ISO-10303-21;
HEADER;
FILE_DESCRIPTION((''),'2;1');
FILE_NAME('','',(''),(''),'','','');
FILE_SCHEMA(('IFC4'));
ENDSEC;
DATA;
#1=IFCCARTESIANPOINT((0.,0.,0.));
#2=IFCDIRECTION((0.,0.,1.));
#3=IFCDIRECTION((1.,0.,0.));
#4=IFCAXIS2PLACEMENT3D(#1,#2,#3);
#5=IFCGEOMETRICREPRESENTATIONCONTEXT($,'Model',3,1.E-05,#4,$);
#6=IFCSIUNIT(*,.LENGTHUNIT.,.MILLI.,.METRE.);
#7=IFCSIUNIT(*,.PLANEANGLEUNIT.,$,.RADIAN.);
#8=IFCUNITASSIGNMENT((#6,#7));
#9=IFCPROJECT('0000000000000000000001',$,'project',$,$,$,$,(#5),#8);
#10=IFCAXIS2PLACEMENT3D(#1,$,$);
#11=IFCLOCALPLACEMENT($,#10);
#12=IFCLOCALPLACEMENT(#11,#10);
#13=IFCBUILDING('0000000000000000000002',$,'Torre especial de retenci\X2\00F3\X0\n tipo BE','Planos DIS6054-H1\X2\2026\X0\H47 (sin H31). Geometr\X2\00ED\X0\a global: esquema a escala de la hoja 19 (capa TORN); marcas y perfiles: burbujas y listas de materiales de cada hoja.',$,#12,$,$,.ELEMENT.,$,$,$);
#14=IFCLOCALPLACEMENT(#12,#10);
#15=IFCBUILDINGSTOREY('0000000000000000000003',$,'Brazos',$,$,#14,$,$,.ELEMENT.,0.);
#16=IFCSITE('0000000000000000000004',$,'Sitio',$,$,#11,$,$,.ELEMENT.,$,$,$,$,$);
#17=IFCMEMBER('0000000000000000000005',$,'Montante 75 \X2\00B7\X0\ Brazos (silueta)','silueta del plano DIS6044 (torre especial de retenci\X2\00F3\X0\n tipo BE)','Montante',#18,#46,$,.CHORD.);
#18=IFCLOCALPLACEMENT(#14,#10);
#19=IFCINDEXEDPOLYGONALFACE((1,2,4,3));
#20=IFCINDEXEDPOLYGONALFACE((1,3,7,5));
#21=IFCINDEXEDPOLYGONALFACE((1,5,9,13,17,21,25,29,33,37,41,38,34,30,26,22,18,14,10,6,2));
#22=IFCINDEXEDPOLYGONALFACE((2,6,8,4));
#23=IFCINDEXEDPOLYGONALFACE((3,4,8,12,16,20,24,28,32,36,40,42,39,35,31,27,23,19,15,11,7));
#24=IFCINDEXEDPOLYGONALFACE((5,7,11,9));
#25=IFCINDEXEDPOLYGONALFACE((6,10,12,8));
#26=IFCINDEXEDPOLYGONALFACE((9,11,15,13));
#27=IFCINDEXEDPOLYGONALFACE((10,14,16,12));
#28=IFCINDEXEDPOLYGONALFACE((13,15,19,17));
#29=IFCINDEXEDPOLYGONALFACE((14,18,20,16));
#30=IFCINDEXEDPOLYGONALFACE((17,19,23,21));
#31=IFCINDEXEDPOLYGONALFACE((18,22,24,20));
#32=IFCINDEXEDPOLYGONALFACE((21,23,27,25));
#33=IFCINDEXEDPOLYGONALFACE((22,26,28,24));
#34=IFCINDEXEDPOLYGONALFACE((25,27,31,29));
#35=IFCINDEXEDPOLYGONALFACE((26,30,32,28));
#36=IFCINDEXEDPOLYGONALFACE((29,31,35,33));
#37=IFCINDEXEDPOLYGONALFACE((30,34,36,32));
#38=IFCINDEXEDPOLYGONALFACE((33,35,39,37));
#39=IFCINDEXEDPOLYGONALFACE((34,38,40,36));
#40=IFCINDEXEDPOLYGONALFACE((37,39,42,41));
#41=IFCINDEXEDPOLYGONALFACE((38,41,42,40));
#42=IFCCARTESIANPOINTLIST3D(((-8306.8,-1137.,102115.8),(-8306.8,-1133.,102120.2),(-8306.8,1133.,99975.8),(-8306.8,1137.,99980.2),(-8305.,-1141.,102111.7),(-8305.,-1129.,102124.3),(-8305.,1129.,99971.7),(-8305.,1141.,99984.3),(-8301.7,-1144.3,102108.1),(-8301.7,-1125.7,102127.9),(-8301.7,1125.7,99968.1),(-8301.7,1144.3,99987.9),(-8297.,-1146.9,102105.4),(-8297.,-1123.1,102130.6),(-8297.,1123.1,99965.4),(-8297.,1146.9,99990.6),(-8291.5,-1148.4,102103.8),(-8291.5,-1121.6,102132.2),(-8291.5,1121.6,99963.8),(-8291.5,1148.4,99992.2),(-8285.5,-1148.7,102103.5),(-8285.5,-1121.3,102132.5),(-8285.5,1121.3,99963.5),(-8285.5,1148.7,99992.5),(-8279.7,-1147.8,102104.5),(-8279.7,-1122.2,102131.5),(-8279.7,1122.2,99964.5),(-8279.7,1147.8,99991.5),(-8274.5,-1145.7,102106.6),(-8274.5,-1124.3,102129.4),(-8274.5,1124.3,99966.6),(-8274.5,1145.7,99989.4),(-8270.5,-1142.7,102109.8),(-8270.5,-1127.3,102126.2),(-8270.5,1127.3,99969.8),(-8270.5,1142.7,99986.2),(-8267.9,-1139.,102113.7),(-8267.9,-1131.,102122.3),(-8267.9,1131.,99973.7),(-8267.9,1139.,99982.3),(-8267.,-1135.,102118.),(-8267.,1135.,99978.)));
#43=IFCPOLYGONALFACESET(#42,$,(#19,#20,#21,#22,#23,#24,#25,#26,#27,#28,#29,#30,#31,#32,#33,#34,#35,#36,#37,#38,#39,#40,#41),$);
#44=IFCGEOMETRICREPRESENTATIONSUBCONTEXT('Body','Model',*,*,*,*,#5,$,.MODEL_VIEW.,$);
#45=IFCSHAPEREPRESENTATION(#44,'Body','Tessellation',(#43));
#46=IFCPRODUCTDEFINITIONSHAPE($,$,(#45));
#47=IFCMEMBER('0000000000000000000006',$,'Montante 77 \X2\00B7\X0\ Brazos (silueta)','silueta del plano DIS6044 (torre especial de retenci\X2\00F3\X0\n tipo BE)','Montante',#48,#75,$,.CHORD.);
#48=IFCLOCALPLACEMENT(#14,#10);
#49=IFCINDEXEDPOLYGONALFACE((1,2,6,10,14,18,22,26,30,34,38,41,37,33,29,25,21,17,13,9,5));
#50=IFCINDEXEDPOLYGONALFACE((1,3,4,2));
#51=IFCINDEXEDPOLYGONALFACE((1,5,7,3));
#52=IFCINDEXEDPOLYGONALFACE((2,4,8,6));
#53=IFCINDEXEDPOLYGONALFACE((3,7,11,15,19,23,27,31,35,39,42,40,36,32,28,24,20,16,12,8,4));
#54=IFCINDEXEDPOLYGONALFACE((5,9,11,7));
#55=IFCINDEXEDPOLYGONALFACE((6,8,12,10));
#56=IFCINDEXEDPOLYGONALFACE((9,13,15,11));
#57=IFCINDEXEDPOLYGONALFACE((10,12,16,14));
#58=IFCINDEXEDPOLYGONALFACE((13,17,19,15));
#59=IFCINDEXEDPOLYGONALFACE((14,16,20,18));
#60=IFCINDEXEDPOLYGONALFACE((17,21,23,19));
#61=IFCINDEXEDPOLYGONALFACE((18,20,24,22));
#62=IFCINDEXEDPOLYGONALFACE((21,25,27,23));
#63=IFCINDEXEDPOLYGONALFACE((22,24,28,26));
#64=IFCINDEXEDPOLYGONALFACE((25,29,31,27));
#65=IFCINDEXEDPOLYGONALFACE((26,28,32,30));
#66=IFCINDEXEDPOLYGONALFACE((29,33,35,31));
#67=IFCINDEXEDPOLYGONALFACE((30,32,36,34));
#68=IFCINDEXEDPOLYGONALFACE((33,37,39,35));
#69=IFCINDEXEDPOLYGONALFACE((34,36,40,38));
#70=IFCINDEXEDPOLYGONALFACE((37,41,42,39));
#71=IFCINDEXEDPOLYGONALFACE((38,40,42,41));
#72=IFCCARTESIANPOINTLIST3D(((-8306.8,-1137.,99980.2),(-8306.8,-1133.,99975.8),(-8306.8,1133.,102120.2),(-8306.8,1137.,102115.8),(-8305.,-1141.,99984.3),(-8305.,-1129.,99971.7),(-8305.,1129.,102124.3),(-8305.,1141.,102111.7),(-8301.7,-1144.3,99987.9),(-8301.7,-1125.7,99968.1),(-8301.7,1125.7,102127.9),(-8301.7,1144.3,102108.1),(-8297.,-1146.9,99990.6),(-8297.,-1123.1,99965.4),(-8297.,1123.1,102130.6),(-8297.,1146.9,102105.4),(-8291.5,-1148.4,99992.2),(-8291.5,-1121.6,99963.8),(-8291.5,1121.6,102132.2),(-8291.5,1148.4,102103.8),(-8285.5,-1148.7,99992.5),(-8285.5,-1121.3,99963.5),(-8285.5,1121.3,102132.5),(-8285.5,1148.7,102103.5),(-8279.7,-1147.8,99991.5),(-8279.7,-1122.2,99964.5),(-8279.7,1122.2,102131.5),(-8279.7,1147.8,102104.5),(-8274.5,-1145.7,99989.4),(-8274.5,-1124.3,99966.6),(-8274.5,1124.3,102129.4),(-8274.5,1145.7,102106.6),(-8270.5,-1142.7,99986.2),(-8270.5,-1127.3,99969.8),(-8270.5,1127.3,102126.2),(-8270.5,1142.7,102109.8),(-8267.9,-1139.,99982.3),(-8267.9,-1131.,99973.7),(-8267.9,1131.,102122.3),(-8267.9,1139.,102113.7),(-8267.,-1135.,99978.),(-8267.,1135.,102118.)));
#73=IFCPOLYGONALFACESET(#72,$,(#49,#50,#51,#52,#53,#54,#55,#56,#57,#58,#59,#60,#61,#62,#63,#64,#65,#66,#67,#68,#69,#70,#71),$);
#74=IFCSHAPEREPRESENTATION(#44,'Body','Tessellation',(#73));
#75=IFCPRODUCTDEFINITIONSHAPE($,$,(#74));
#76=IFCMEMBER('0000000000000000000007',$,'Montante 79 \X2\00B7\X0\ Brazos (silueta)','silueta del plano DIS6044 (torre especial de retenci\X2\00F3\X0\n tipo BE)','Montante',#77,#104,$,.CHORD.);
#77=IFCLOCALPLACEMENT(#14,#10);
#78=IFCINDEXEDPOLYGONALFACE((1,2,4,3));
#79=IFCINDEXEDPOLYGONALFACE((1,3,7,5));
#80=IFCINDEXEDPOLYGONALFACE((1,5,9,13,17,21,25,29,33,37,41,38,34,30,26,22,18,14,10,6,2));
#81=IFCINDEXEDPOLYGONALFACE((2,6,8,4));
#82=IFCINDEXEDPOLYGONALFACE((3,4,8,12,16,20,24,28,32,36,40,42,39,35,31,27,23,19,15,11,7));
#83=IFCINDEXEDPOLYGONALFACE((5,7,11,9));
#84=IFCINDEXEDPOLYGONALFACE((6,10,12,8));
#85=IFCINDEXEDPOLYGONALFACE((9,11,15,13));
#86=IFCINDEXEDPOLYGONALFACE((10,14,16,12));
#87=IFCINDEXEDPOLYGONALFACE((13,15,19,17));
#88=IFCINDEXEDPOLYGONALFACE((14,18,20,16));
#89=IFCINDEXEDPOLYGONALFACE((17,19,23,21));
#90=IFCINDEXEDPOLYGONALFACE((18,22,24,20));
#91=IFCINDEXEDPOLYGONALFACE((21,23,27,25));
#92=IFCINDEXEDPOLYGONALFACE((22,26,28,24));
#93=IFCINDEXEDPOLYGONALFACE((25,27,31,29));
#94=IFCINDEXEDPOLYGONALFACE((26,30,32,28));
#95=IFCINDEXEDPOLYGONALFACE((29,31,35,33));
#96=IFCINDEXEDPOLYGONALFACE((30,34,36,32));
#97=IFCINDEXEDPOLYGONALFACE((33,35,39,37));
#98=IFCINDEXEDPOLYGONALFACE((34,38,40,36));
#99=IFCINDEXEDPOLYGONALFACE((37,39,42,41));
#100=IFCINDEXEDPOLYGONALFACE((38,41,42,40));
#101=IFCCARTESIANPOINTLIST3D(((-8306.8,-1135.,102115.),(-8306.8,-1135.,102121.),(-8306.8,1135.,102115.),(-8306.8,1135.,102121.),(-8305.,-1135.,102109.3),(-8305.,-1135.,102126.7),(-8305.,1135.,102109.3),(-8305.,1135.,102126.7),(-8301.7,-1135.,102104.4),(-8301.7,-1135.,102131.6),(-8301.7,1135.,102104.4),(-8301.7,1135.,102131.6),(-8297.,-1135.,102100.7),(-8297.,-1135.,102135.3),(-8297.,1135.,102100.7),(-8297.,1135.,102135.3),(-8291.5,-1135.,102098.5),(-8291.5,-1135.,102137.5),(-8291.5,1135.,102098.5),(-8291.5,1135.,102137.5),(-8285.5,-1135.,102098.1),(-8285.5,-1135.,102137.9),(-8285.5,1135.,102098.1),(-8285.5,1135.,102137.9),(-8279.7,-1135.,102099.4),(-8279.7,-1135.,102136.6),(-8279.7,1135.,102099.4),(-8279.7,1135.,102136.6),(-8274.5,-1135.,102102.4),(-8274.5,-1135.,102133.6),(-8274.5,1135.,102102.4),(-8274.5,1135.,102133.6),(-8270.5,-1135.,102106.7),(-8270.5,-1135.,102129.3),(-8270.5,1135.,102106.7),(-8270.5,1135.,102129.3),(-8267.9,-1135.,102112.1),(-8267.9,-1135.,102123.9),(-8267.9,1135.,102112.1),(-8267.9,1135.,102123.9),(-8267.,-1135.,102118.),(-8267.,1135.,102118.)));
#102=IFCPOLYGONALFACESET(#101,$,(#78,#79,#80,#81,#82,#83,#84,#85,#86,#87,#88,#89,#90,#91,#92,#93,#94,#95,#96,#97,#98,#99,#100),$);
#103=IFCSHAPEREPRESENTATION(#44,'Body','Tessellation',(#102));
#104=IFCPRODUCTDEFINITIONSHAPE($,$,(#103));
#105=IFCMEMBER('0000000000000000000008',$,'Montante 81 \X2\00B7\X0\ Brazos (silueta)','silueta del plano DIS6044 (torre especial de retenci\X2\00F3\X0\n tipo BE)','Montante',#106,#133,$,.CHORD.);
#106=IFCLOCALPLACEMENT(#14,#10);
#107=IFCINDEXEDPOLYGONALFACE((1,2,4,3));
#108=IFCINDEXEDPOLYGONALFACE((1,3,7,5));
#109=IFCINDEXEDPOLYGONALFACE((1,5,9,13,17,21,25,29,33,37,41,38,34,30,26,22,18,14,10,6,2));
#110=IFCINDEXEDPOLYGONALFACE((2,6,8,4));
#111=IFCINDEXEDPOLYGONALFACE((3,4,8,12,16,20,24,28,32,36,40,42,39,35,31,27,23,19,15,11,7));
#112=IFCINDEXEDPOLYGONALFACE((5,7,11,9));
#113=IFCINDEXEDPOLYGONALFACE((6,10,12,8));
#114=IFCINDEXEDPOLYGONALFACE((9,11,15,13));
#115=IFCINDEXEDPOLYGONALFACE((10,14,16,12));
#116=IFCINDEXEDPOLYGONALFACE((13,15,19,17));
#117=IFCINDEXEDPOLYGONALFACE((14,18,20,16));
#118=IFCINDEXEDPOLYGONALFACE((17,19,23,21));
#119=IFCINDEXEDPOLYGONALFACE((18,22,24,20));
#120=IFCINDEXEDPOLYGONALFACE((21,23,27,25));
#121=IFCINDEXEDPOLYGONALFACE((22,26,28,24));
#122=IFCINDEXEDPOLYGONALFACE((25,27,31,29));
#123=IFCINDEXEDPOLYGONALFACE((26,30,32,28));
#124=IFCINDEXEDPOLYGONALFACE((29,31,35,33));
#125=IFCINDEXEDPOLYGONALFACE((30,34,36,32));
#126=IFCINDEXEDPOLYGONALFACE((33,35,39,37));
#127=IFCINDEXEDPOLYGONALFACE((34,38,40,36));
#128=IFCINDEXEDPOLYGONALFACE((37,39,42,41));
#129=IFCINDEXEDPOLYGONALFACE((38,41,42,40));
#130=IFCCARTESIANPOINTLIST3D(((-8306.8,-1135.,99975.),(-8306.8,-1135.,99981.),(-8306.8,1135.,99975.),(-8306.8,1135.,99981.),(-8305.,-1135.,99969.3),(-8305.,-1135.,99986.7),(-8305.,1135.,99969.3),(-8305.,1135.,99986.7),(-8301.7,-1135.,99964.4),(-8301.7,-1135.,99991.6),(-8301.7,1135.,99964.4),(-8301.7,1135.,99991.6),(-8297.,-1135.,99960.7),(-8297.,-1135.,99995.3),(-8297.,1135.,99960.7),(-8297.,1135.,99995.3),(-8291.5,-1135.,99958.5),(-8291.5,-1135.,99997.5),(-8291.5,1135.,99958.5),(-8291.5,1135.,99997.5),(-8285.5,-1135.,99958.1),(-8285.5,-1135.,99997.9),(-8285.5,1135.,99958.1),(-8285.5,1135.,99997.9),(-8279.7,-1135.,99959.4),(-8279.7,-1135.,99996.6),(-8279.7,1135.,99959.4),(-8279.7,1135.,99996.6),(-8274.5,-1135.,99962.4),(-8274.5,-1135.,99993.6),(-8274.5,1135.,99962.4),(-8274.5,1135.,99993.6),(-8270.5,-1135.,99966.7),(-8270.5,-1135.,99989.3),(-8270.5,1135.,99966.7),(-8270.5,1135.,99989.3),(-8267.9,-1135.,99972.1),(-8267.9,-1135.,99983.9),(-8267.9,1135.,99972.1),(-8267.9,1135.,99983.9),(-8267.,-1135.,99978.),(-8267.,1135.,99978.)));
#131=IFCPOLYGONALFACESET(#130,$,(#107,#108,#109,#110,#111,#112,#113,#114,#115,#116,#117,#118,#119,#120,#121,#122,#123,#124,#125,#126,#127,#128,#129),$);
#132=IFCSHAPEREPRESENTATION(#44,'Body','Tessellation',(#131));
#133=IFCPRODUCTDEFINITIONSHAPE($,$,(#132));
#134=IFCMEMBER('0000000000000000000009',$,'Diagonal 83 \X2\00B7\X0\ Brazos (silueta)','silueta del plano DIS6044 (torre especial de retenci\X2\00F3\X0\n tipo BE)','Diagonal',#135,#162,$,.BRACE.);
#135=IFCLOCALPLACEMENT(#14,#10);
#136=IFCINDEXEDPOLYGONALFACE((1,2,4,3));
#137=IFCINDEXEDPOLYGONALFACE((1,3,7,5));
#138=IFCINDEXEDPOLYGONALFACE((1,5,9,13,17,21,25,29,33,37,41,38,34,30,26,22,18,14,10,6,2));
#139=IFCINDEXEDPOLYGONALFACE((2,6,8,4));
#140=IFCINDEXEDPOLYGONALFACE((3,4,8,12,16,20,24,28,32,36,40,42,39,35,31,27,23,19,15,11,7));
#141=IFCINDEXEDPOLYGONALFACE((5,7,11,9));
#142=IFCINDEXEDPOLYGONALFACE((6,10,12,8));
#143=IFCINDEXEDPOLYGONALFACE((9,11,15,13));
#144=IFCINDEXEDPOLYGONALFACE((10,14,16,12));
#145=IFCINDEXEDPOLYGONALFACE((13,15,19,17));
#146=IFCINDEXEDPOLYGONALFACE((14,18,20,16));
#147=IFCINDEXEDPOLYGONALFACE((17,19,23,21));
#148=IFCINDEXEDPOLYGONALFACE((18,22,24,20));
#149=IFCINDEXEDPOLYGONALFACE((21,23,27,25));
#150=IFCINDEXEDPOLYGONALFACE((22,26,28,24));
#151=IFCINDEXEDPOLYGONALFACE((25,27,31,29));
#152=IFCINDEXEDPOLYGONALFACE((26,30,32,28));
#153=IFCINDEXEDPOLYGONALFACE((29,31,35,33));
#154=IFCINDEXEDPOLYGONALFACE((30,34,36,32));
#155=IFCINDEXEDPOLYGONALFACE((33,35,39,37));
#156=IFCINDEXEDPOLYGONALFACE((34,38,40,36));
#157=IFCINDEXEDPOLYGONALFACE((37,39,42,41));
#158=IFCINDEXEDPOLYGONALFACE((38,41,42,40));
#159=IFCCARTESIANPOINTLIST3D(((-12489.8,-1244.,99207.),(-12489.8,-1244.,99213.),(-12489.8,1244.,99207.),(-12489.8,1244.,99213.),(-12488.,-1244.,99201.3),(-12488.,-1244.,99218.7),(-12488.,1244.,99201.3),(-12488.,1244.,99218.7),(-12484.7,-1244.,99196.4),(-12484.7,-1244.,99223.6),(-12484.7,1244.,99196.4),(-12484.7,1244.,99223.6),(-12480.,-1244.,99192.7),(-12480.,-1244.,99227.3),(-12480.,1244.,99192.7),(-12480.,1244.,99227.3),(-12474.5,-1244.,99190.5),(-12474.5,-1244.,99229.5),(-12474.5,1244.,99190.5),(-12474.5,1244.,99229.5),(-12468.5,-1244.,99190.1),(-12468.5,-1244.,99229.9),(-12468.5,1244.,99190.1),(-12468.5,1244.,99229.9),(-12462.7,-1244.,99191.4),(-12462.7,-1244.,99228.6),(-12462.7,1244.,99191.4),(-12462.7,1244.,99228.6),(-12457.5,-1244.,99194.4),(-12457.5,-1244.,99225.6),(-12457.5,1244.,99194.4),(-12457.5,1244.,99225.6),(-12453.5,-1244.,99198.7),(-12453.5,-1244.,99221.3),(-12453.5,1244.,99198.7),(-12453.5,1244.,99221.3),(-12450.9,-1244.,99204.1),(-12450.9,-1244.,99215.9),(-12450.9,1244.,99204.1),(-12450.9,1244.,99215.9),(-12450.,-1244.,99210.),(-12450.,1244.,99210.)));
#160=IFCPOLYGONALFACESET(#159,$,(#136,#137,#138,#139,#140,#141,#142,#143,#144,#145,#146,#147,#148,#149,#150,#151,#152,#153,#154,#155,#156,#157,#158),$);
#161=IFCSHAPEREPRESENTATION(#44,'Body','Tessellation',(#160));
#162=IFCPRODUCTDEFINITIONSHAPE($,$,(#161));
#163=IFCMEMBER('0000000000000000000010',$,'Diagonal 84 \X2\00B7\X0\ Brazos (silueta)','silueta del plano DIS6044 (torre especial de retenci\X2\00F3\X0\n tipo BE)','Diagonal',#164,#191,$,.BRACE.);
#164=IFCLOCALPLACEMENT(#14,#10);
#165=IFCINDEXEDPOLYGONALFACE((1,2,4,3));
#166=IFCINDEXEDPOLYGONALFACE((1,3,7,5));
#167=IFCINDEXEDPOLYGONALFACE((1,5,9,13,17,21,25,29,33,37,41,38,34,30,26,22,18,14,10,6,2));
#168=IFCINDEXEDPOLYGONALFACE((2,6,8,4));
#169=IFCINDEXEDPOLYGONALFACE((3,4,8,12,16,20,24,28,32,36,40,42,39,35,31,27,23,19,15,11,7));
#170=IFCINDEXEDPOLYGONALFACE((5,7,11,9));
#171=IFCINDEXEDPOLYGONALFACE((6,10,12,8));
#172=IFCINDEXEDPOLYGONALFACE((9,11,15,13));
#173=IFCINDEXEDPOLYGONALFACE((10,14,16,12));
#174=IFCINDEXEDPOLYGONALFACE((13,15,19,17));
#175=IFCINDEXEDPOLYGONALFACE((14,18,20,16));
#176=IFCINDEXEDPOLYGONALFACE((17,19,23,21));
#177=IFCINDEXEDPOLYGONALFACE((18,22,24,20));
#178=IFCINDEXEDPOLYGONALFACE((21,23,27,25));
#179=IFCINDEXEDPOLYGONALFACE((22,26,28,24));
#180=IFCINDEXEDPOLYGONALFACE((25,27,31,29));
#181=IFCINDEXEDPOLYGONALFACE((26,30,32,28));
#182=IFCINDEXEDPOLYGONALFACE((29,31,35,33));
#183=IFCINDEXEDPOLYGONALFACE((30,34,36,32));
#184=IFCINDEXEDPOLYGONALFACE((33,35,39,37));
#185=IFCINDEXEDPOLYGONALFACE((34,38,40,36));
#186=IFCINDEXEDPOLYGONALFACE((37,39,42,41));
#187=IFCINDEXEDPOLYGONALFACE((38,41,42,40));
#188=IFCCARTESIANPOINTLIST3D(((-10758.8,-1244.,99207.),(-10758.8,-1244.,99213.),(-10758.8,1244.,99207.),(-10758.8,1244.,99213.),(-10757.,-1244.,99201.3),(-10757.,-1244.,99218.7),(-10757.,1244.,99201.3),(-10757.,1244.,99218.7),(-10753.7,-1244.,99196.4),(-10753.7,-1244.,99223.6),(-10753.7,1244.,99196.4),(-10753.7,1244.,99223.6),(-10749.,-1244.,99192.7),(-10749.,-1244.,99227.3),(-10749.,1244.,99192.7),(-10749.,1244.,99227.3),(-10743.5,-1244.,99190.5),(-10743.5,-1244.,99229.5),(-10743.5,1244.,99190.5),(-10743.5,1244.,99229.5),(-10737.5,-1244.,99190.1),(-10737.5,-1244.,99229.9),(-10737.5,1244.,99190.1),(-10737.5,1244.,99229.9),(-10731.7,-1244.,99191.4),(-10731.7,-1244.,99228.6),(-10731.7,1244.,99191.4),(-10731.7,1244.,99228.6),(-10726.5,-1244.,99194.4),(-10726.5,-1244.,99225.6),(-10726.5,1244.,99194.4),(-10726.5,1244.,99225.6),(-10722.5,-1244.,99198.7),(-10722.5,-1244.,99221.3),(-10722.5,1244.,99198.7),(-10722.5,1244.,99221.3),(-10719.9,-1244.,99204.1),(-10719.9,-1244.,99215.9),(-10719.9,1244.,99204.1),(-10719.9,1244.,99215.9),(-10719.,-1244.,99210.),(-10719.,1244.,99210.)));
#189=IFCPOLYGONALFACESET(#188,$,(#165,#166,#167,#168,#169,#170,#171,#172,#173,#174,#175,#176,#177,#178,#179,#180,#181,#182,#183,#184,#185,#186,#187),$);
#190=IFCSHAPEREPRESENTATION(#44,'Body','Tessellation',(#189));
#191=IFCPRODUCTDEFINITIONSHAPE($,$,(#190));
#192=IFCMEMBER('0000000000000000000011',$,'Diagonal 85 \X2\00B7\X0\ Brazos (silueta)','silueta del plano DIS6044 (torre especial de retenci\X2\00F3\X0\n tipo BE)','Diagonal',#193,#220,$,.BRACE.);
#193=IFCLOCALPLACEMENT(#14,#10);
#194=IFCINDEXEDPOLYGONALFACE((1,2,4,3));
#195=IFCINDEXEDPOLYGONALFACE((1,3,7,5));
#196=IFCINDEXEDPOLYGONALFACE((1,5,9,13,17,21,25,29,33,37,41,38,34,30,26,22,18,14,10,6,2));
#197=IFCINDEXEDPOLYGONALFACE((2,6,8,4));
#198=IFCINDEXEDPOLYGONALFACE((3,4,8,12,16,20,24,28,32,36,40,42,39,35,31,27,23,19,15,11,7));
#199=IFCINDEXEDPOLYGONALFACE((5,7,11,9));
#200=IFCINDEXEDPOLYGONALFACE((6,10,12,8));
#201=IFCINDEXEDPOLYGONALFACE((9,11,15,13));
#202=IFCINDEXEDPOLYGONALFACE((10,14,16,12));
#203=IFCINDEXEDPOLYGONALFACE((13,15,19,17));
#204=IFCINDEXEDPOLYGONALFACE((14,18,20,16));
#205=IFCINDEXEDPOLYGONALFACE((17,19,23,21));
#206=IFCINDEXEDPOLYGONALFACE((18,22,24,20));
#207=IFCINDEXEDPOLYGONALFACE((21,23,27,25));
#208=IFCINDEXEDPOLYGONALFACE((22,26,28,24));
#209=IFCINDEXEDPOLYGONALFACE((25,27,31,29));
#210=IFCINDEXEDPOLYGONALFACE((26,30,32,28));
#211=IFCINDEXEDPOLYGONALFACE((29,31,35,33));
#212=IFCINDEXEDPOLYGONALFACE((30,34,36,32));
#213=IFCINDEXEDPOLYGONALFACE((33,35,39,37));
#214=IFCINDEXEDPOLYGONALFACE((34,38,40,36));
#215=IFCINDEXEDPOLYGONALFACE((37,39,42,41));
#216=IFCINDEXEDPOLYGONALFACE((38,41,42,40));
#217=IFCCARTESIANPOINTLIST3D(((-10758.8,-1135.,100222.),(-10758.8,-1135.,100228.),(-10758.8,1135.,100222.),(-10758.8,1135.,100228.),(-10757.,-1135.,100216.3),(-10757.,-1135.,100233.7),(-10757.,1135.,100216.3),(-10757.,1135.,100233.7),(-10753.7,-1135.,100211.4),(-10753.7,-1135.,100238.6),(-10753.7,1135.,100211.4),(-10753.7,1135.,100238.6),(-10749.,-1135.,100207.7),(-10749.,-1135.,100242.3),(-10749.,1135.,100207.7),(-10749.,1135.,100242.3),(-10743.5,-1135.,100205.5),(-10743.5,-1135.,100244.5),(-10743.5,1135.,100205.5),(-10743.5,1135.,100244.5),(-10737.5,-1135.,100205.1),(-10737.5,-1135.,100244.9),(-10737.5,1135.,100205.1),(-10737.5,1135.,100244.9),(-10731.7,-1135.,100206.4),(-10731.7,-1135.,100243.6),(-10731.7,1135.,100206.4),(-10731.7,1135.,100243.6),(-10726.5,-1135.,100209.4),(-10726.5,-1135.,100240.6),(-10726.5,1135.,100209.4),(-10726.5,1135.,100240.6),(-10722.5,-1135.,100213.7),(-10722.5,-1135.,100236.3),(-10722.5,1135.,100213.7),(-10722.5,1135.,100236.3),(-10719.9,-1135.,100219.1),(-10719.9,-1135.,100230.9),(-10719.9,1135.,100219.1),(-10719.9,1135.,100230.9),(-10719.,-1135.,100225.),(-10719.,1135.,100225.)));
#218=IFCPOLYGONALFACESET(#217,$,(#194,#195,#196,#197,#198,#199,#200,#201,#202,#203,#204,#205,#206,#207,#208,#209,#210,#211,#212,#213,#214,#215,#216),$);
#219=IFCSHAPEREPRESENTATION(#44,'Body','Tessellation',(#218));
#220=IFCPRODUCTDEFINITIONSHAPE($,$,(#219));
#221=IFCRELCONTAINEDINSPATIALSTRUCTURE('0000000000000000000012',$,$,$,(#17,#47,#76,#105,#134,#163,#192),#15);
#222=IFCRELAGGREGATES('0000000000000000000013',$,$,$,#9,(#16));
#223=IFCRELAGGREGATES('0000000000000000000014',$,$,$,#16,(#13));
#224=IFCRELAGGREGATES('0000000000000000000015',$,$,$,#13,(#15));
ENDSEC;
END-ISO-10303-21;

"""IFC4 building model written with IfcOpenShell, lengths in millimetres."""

from ifc_helpers import new_model, si_unit, frame, origin, origin_with_axes, place, context, subcontext, project, spatial, circle, extrude, element, save


model = new_model("IFC4")

# Units and contexts
model_context = context("Model", 3, precision=1e-05, world=origin_with_axes())
body_context = subcontext(model_context, "Body", "Model", "MODEL_VIEW")
ifc_project = project(units=[si_unit("LENGTHUNIT", "METRE", prefix="MILLI"), si_unit("PLANEANGLEUNIT", "RADIAN")], contexts=[model_context])

# Site, building, storey
site_placement = place(None, origin())
site = spatial("IfcSite", under=ifc_project, at=site_placement, Name="Sitio", CompositionType="ELEMENT")
building_placement = place(site_placement, origin())
building = spatial("IfcBuilding", under=site, at=building_placement, Name="Torre especial de retención tipo BE", Description="Planos DIS6054-H1…H47 (sin H31). Geometría global: esquema a escala de la hoja 19 (capa TORN); marcas y perfiles: burbujas y listas de materiales de cada hoja.", CompositionType="ELEMENT")
storey_placement = place(building_placement, origin())
storey = spatial("IfcBuildingStorey", under=building, at=storey_placement, Name="Brazos", CompositionType="ELEMENT", Elevation=0.0)

# Members
for number, where, z_axis, x_axis, name in (
    (1, (-8287.0, -1135.0, 102118.0), (0.0, 0.727635, -0.685964), (1.0, 0.0, 0.0), "Montante 75 · Brazos (silueta)"),
    (2, (-8287.0, 1135.0, 102118.0), (0.0, -0.727635, -0.685964), (1.0, 0.0, 0.0), "Montante 77 · Brazos (silueta)"),
):
    element("IfcMember", number, at=place(storey_placement, frame(where, z_axis=z_axis, x_axis=x_axis)), inside=storey, Name=name, Description="silueta del plano DIS6044 (torre especial de retención tipo BE)", ObjectType="Montante", PredefinedType="CHORD", context=body_context, shape_type="SweptSolid", body=[
        extrude(circle(Radius=20.0), None, (0.0, 0.0, 1.0), 3119.7),
    ])
for number, where, z_axis, x_axis, name in (
    (3, (-8287.0, 1135.0, 102118.0), (0.0, -1.0, 0.0), (1.0, 0.0, 0.0), "Montante 79 · Brazos (silueta)"),
    (4, (-8287.0, 1135.0, 99978.0), (0.0, -1.0, 0.0), (1.0, 0.0, 0.0), "Montante 81 · Brazos (silueta)"),
):
    element("IfcMember", number, at=place(storey_placement, frame(where, z_axis=z_axis, x_axis=x_axis)), inside=storey, Name=name, Description="silueta del plano DIS6044 (torre especial de retención tipo BE)", ObjectType="Montante", PredefinedType="CHORD", context=body_context, shape_type="SweptSolid", body=[
        extrude(circle(Radius=20.0), None, (0.0, 0.0, 1.0), 2270.0),
    ])
for number, where, z_axis, x_axis, name in (
    (5, (-12470.0, 1244.0, 99210.0), (0.0, -1.0, 0.0), (1.0, 0.0, 0.0), "Diagonal 83 · Brazos (silueta)"),
    (6, (-10739.0, 1244.0, 99210.0), (0.0, -1.0, 0.0), (1.0, 0.0, 0.0), "Diagonal 84 · Brazos (silueta)"),
):
    element("IfcMember", number, at=place(storey_placement, frame(where, z_axis=z_axis, x_axis=x_axis)), inside=storey, Name=name, Description="silueta del plano DIS6044 (torre especial de retención tipo BE)", ObjectType="Diagonal", PredefinedType="BRACE", context=body_context, shape_type="SweptSolid", body=[
        extrude(circle(Radius=20.0), None, (0.0, 0.0, 1.0), 2488.0),
    ])
member_1_placement = place(storey_placement, frame((-10739.0, 1135.0, 100225.0), z_axis=(0.0, -1.0, 0.0), x_axis=(1.0, 0.0, 0.0)))
element("IfcMember", 7, at=member_1_placement, inside=storey, Name="Diagonal 85 · Brazos (silueta)", Description="silueta del plano DIS6044 (torre especial de retención tipo BE)", ObjectType="Diagonal", PredefinedType="BRACE", context=body_context, shape_type="SweptSolid", body=[
    extrude(circle(Radius=20.0), None, (0.0, 0.0, 1.0), 2270.0),
])

save(model, "model.ifc")
